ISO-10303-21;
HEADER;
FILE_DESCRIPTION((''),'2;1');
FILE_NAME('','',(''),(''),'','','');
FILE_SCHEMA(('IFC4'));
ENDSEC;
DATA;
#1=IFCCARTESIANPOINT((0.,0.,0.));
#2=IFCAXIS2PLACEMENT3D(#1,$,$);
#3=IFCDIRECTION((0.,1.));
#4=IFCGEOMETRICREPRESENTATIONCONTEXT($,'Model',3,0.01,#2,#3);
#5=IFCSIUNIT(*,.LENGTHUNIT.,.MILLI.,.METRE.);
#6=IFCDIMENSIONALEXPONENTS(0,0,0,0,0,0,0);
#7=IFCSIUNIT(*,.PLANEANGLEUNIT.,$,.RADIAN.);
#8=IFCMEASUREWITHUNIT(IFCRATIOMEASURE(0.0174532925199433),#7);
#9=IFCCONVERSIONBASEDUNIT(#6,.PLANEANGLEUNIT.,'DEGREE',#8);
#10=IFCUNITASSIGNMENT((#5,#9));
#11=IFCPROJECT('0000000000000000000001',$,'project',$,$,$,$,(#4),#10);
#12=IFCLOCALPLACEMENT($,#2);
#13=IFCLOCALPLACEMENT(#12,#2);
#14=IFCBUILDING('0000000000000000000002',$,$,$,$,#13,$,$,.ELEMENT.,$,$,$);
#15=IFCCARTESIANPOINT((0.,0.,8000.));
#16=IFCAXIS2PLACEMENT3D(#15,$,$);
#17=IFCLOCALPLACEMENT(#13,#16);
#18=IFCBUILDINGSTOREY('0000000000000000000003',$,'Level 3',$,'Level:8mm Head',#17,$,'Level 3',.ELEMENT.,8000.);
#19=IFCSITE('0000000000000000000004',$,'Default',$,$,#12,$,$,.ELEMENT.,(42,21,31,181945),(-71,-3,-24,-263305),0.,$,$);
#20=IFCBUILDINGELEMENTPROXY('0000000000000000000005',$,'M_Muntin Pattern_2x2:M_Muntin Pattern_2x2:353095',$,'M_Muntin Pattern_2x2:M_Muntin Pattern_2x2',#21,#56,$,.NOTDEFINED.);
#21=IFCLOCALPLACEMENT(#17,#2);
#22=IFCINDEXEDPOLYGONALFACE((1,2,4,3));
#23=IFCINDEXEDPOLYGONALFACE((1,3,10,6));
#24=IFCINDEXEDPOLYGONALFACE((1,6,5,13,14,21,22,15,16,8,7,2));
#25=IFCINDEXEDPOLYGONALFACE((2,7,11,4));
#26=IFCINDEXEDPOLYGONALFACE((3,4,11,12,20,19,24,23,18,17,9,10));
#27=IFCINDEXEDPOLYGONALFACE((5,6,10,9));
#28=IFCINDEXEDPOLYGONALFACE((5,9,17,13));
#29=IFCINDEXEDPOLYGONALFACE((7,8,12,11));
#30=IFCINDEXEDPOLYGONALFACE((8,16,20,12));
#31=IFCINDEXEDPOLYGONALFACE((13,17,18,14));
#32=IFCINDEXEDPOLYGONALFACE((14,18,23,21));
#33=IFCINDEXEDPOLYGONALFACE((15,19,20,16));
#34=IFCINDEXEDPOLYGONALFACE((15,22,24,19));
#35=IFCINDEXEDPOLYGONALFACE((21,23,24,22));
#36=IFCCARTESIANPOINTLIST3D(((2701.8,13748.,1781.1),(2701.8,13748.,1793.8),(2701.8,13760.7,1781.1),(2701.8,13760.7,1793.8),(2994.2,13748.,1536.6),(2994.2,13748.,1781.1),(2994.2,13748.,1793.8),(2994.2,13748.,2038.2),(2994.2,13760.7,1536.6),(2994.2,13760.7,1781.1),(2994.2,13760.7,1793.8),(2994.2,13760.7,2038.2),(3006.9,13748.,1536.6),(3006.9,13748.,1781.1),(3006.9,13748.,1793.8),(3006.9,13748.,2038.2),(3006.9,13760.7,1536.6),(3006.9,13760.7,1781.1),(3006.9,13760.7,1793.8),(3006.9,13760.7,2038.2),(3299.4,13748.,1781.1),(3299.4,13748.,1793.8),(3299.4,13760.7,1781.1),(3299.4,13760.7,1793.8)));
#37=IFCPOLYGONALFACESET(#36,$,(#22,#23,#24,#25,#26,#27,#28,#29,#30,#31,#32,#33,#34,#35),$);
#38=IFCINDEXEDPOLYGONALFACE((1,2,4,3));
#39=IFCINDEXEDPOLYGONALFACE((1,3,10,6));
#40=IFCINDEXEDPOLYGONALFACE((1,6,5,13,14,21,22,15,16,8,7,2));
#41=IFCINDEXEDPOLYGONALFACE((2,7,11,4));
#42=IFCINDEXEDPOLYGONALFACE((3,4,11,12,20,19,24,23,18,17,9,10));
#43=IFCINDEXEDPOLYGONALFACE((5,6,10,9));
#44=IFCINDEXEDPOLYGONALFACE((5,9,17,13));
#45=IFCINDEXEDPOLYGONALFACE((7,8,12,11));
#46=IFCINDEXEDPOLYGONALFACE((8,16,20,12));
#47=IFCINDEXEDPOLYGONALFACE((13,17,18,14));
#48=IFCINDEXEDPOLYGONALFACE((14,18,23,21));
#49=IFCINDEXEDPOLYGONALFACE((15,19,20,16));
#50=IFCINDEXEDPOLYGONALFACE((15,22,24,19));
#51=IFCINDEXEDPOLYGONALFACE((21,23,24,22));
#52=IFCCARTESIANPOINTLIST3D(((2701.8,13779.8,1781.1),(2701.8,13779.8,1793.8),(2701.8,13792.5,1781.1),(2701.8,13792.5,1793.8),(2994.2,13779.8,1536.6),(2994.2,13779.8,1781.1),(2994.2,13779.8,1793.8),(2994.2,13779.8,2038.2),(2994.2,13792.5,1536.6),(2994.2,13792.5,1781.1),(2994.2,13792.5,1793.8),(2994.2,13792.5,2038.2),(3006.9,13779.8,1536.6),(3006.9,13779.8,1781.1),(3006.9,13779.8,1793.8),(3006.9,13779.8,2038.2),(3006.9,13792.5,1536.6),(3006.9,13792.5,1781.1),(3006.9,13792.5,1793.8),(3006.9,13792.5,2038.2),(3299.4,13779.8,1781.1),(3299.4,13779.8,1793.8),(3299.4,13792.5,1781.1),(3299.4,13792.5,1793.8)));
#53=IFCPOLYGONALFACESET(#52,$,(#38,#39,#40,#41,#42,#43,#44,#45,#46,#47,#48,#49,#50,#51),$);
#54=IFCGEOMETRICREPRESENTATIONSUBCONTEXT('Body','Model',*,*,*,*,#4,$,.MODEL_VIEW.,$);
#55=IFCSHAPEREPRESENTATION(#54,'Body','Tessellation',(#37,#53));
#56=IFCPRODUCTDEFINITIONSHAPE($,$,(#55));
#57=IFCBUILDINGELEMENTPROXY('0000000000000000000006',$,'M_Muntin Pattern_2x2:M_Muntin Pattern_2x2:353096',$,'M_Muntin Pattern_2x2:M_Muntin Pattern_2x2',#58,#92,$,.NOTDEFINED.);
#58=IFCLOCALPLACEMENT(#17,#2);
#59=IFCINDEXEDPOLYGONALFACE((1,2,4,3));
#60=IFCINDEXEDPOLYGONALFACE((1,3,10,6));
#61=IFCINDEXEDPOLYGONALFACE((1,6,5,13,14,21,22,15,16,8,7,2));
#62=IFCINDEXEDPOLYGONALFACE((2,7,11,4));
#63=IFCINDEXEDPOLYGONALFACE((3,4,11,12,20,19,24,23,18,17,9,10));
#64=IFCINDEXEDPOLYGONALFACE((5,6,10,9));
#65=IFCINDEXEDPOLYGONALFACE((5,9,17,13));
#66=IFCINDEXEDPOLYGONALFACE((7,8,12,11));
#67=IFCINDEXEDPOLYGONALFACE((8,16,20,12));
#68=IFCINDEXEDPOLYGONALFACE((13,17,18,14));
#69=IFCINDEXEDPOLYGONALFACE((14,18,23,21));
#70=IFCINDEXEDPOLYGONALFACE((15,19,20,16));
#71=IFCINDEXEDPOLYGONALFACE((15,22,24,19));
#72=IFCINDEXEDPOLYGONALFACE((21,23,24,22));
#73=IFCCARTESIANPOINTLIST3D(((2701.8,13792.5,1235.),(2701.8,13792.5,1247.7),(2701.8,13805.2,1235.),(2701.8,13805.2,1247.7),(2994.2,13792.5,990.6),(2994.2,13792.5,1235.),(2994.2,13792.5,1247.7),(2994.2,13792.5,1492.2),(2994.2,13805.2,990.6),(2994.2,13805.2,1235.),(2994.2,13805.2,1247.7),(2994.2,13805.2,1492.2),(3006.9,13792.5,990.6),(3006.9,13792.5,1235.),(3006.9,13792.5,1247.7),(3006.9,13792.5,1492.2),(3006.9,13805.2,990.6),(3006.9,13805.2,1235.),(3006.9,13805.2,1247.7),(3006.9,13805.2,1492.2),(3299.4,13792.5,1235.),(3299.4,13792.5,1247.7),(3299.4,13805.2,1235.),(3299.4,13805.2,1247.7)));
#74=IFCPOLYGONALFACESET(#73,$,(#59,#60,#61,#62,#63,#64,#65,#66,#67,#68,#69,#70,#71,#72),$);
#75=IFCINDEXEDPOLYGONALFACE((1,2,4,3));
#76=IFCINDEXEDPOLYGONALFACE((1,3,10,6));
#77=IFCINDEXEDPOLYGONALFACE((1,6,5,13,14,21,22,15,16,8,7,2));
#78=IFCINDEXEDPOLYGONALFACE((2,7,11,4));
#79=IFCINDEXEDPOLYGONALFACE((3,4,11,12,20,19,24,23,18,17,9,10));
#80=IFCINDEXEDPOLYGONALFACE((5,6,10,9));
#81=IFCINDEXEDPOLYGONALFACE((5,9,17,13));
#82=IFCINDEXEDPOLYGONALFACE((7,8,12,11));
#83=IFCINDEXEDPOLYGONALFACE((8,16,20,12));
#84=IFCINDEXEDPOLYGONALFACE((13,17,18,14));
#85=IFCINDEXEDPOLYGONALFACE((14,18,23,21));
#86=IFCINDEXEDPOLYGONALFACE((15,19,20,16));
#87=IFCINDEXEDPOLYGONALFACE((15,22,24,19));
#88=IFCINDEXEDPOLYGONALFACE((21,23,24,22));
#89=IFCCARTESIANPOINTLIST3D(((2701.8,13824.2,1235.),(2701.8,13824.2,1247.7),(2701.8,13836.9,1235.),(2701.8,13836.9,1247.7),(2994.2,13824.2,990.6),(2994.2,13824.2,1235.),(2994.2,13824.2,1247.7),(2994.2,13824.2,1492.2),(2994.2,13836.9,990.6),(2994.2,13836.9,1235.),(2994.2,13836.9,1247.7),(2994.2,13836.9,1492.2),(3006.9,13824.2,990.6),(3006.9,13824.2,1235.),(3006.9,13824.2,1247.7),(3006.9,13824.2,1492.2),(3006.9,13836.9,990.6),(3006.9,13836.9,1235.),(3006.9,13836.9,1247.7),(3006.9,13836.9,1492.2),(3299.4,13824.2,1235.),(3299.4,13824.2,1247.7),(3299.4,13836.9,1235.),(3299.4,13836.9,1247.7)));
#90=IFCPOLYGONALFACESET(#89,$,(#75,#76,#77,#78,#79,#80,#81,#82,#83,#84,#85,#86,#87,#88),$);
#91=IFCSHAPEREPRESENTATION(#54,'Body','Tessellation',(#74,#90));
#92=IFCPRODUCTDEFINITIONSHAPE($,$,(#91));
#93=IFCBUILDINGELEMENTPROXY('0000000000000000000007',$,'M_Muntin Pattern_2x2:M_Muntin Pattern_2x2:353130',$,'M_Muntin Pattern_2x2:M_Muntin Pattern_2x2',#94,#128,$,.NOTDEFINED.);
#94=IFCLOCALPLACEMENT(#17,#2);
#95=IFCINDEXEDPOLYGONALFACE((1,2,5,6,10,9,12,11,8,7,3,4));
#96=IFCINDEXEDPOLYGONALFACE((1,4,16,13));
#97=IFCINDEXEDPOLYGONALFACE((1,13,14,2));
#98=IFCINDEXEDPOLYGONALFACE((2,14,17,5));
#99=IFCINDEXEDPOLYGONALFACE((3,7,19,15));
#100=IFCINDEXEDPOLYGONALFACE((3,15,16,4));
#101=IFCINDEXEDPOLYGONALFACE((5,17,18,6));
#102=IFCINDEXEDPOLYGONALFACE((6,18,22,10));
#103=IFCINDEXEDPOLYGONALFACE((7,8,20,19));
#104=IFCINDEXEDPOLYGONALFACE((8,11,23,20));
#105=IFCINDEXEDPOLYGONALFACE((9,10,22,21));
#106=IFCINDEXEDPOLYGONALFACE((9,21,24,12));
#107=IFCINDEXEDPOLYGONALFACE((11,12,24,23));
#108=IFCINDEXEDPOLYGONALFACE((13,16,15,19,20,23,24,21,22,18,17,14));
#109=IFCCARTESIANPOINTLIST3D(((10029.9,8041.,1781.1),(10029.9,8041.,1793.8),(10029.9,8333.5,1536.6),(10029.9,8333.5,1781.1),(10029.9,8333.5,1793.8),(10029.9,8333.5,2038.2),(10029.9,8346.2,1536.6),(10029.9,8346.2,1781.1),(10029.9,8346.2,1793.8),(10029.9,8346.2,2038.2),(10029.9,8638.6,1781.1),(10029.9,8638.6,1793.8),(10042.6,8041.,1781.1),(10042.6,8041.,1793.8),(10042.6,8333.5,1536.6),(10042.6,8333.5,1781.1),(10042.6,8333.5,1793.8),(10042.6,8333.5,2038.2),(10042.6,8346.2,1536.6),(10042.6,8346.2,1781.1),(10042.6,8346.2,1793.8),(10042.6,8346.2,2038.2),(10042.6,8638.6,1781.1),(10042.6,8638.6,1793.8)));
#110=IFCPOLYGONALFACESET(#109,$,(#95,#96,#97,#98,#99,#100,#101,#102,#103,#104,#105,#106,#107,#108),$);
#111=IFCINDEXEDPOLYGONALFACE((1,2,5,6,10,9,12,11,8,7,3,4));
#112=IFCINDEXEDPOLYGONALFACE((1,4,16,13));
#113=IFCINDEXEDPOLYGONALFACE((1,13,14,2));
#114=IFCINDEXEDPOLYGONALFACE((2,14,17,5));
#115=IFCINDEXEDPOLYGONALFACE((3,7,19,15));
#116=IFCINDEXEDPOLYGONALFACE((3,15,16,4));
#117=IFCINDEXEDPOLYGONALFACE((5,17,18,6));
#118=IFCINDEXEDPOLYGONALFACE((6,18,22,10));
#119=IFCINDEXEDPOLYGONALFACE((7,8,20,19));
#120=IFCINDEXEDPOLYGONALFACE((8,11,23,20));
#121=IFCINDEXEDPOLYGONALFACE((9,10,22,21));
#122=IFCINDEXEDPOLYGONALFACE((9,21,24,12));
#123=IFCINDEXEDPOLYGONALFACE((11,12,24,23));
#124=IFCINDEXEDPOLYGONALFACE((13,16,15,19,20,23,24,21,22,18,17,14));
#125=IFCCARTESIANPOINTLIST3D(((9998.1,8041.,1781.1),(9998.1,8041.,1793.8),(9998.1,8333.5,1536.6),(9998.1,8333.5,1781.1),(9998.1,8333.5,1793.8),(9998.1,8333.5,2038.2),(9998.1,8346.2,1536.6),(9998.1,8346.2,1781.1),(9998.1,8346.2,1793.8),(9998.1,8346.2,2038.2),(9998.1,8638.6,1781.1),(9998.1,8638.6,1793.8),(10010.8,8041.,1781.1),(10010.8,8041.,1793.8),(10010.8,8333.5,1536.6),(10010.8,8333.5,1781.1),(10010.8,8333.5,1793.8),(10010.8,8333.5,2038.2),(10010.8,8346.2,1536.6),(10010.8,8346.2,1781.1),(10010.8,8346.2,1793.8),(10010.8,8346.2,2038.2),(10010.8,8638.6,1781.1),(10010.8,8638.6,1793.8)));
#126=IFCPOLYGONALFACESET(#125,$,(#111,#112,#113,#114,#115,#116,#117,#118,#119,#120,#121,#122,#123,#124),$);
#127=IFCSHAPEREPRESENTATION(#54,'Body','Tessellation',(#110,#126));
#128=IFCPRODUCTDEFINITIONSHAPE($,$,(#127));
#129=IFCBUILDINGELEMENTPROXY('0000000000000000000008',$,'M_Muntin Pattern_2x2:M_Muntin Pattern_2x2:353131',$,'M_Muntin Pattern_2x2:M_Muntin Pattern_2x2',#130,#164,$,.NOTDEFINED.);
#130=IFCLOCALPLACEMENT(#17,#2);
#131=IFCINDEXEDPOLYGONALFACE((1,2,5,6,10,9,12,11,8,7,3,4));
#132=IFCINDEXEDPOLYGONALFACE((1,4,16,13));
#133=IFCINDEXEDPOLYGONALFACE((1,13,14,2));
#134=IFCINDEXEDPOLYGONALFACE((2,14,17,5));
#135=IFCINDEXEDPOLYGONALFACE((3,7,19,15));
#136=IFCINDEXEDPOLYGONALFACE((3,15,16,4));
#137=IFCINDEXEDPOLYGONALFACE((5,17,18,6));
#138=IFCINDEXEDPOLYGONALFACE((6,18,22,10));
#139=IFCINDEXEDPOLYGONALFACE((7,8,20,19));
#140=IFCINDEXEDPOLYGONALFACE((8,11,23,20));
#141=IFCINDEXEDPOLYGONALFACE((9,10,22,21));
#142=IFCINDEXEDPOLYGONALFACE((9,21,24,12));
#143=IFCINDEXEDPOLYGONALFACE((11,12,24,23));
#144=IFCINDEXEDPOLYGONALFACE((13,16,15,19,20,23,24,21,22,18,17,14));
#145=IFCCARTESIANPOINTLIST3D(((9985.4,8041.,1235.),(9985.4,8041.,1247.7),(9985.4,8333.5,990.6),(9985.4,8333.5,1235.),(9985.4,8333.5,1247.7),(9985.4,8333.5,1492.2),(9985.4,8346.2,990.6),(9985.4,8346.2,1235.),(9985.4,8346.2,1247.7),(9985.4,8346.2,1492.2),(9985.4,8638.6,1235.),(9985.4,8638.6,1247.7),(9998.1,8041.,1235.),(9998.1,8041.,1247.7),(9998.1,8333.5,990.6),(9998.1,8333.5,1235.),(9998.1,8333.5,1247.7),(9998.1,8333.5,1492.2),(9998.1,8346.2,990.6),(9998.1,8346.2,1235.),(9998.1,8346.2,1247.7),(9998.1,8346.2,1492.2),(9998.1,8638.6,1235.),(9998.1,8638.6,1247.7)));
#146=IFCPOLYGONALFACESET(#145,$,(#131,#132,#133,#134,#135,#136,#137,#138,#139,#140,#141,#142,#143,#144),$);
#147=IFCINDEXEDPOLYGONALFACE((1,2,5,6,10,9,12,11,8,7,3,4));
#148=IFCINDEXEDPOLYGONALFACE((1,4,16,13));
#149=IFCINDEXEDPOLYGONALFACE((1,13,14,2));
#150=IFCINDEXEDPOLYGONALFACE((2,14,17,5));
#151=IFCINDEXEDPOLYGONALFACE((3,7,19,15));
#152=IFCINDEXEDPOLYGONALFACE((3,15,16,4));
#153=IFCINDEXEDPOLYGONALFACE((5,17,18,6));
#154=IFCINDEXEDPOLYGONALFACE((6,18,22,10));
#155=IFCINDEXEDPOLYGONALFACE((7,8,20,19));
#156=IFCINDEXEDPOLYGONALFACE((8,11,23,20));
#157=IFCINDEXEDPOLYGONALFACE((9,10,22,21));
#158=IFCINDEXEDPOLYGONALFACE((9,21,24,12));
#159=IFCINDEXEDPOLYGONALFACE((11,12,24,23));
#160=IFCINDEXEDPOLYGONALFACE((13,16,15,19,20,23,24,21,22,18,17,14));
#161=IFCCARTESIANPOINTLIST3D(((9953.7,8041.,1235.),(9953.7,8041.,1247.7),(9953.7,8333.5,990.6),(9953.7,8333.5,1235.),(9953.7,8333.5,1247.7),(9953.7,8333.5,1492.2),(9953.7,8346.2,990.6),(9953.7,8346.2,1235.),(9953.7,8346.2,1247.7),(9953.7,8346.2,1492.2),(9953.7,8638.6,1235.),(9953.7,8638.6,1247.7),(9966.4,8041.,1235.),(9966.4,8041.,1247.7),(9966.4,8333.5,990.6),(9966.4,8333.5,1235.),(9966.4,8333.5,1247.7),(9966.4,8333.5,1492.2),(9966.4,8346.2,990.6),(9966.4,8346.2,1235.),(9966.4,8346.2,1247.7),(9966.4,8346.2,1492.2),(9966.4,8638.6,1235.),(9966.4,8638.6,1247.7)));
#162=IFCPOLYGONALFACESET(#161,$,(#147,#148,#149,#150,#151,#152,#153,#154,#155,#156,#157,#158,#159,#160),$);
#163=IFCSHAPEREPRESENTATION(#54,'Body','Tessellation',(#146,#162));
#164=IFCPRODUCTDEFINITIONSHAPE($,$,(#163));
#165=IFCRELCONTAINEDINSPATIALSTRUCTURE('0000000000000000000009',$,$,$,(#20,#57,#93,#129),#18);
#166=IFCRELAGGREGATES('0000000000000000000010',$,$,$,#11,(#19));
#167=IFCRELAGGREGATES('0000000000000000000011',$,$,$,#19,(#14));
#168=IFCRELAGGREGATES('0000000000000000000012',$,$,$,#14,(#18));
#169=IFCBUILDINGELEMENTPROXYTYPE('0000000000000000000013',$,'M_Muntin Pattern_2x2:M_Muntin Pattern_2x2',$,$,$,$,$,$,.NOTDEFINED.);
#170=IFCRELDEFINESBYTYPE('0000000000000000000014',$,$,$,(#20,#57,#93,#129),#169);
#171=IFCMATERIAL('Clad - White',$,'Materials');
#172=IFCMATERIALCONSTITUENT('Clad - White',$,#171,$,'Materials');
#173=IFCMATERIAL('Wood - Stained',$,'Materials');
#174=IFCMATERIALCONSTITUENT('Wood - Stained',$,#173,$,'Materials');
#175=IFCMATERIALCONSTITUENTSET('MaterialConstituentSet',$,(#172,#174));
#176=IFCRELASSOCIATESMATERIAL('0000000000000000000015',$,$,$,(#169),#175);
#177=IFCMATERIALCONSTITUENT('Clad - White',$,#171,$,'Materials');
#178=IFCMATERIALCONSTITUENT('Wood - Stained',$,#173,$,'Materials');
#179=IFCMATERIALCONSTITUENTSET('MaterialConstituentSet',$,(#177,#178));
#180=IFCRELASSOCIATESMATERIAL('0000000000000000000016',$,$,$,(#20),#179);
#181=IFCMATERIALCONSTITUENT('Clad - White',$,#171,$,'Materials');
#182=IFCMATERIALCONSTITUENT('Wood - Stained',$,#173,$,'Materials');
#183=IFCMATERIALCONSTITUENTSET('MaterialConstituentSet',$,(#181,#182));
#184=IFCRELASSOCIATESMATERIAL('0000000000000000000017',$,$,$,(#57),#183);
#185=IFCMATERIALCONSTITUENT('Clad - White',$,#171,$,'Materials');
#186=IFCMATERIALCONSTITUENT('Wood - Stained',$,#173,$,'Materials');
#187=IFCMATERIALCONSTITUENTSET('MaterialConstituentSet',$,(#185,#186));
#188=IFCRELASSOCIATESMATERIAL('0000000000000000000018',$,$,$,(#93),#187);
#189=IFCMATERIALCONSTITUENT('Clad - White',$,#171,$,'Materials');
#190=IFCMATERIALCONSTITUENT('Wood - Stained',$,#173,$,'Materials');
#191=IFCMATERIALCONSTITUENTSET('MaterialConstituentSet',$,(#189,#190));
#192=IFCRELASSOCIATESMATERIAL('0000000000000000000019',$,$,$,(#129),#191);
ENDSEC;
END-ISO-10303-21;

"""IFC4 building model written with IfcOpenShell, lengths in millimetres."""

from ifc_helpers import new_model, entity, si_unit, converted_unit, direction, frame, origin, place, context, subcontext, project, spatial, polyline, outline, extrude, source, transform, mapped, material, constituent, constituent_set, type_object, type_shapes, element, save


model = new_model("IFC4")

# Units and contexts
model_context = context("Model", 3, precision=0.01, world=origin(), true_north=direction((0.0, 1.0)))
body_context = subcontext(model_context, "Body", "Model", "MODEL_VIEW")
ifc_project = project(units=[si_unit("LENGTHUNIT", "METRE", prefix="MILLI"), converted_unit("PLANEANGLEUNIT", "DEGREE", entity("IfcRatioMeasure", 0.0174532925199433), si_unit("PLANEANGLEUNIT", "RADIAN"), dimensions=[0, 0, 0, 0, 0, 0, 0])], contexts=[model_context])

# Site, building, storey
site_placement = place(None, origin())
site = spatial("IfcSite", under=ifc_project, at=site_placement, Name="Default", CompositionType="ELEMENT", RefLatitude=(42, 21, 31, 181945), RefLongitude=(-71, -3, -24, -263305), RefElevation=0.0)
building_placement = place(site_placement, origin())
building = spatial("IfcBuilding", under=site, at=building_placement, CompositionType="ELEMENT")
storey_placement = place(building_placement, frame((0.0, 0.0, 8000.0)))
storey = spatial("IfcBuildingStorey", under=building, at=storey_placement, Name="Level 3", ObjectType="Level:8mm Head", LongName="Level 3", CompositionType="ELEMENT", Elevation=8000.0)

# Shared definitions
ifc_material_1 = material(Name="Wood - Stained", Category="Materials")

# Building element proxies
ifc_material_2 = material(Name="Clad - White", Category="Materials")
ifc_constituent_1 = constituent(ifc_material_2, Name="Clad - White", Category="Materials")
ifc_constituent_2 = constituent(ifc_material_1, Name="Wood - Stained", Category="Materials")
ifc_constituent_set_1 = constituent_set(constituents=[ifc_constituent_1, ifc_constituent_2], Name="MaterialConstituentSet")
building_element_proxy_type_1 = type_object("IfcBuildingElementProxyType", Name="M_Muntin Pattern_2x2:M_Muntin Pattern_2x2", PredefinedType="NOTDEFINED", material=ifc_constituent_set_1)
shared_shape_1 = source(origin(), body_context, "Body", "SweptSolid", [
    extrude(outline(polyline([(6.4, -6.4), (250.8, -6.4), (250.8, 6.3), (6.4, 6.3), (6.4, 298.8), (-6.3, 298.8), (-6.3, 6.3), (-250.8, 6.3), (-250.8, -6.4), (-6.3, -6.4), (-6.3, -298.8), (6.4, -298.8), (6.4, -6.4)])), frame((0.0, 9.5, 250.8), z_axis=(0.0, 1.0, 0.0), x_axis=(0.0, 0.0, 1.0)), (0.0, 0.0, 1.0), 12.7),
    extrude(outline(polyline([(6.4, -6.4), (250.8, -6.4), (250.8, 6.3), (6.4, 6.3), (6.4, 298.8), (-6.3, 298.8), (-6.3, 6.3), (-250.8, 6.3), (-250.8, -6.4), (-6.3, -6.4), (-6.3, -298.8), (6.4, -298.8), (6.4, -6.4)])), frame((0.0, -22.2, 250.8), z_axis=(0.0, 1.0, 0.0), x_axis=(0.0, 0.0, 1.0)), (0.0, 0.0, 1.0), 12.7),
])
type_shapes(building_element_proxy_type_1, [shared_shape_1])
ifc_constituent_3 = constituent(ifc_material_2, Name="Clad - White", Category="Materials")
ifc_constituent_4 = constituent(ifc_material_1, Name="Wood - Stained", Category="Materials")
ifc_constituent_set_2 = constituent_set(constituents=[ifc_constituent_3, ifc_constituent_4], Name="MaterialConstituentSet")
proxy_1_placement = place(storey_placement, frame((3000.6, 13770.3, 1536.6), z_axis=(0.0, 0.0, 1.0), x_axis=(-1.0, 0.0, 0.0)))
element("IfcBuildingElementProxy", 1, at=proxy_1_placement, inside=storey, type_object=building_element_proxy_type_1, material=ifc_constituent_set_2, Name="M_Muntin Pattern_2x2:M_Muntin Pattern_2x2:353095", ObjectType="M_Muntin Pattern_2x2:M_Muntin Pattern_2x2", PredefinedType="NOTDEFINED", context=body_context, shape_type="MappedRepresentation", body=[
    mapped(shared_shape_1, transform((0.0, 0.0, 0.0), scale=1.0)),
])
ifc_constituent_5 = constituent(ifc_material_2, Name="Clad - White", Category="Materials")
ifc_constituent_6 = constituent(ifc_material_1, Name="Wood - Stained", Category="Materials")
ifc_constituent_set_3 = constituent_set(constituents=[ifc_constituent_5, ifc_constituent_6], Name="MaterialConstituentSet")
proxy_2_placement = place(storey_placement, frame((3000.6, 13814.7, 990.6), z_axis=(0.0, 0.0, 1.0), x_axis=(-1.0, 0.0, 0.0)))
element("IfcBuildingElementProxy", 2, at=proxy_2_placement, inside=storey, type_object=building_element_proxy_type_1, material=ifc_constituent_set_3, Name="M_Muntin Pattern_2x2:M_Muntin Pattern_2x2:353096", ObjectType="M_Muntin Pattern_2x2:M_Muntin Pattern_2x2", PredefinedType="NOTDEFINED", context=body_context, shape_type="MappedRepresentation", body=[
    mapped(shared_shape_1, transform((0.0, 0.0, 0.0), scale=1.0)),
])
ifc_constituent_7 = constituent(ifc_material_2, Name="Clad - White", Category="Materials")
ifc_constituent_8 = constituent(ifc_material_1, Name="Wood - Stained", Category="Materials")
ifc_constituent_set_4 = constituent_set(constituents=[ifc_constituent_7, ifc_constituent_8], Name="MaterialConstituentSet")
proxy_3_placement = place(storey_placement, frame((10020.3, 8339.8, 1536.6), z_axis=(0.0, 0.0, 1.0), x_axis=(0.0, -1.0, 0.0)))
element("IfcBuildingElementProxy", 3, at=proxy_3_placement, inside=storey, type_object=building_element_proxy_type_1, material=ifc_constituent_set_4, Name="M_Muntin Pattern_2x2:M_Muntin Pattern_2x2:353130", ObjectType="M_Muntin Pattern_2x2:M_Muntin Pattern_2x2", PredefinedType="NOTDEFINED", context=body_context, shape_type="MappedRepresentation", body=[
    mapped(shared_shape_1, transform((0.0, 0.0, 0.0), scale=1.0)),
])
ifc_constituent_9 = constituent(ifc_material_2, Name="Clad - White", Category="Materials")
ifc_constituent_10 = constituent(ifc_material_1, Name="Wood - Stained", Category="Materials")
ifc_constituent_set_5 = constituent_set(constituents=[ifc_constituent_9, ifc_constituent_10], Name="MaterialConstituentSet")
proxy_4_placement = place(storey_placement, frame((9975.9, 8339.8, 990.6), z_axis=(0.0, 0.0, 1.0), x_axis=(0.0, -1.0, 0.0)))
element("IfcBuildingElementProxy", 4, at=proxy_4_placement, inside=storey, type_object=building_element_proxy_type_1, material=ifc_constituent_set_5, Name="M_Muntin Pattern_2x2:M_Muntin Pattern_2x2:353131", ObjectType="M_Muntin Pattern_2x2:M_Muntin Pattern_2x2", PredefinedType="NOTDEFINED", context=body_context, shape_type="MappedRepresentation", body=[
    mapped(shared_shape_1, transform((0.0, 0.0, 0.0), scale=1.0)),
])

save(model, "model.ifc")
